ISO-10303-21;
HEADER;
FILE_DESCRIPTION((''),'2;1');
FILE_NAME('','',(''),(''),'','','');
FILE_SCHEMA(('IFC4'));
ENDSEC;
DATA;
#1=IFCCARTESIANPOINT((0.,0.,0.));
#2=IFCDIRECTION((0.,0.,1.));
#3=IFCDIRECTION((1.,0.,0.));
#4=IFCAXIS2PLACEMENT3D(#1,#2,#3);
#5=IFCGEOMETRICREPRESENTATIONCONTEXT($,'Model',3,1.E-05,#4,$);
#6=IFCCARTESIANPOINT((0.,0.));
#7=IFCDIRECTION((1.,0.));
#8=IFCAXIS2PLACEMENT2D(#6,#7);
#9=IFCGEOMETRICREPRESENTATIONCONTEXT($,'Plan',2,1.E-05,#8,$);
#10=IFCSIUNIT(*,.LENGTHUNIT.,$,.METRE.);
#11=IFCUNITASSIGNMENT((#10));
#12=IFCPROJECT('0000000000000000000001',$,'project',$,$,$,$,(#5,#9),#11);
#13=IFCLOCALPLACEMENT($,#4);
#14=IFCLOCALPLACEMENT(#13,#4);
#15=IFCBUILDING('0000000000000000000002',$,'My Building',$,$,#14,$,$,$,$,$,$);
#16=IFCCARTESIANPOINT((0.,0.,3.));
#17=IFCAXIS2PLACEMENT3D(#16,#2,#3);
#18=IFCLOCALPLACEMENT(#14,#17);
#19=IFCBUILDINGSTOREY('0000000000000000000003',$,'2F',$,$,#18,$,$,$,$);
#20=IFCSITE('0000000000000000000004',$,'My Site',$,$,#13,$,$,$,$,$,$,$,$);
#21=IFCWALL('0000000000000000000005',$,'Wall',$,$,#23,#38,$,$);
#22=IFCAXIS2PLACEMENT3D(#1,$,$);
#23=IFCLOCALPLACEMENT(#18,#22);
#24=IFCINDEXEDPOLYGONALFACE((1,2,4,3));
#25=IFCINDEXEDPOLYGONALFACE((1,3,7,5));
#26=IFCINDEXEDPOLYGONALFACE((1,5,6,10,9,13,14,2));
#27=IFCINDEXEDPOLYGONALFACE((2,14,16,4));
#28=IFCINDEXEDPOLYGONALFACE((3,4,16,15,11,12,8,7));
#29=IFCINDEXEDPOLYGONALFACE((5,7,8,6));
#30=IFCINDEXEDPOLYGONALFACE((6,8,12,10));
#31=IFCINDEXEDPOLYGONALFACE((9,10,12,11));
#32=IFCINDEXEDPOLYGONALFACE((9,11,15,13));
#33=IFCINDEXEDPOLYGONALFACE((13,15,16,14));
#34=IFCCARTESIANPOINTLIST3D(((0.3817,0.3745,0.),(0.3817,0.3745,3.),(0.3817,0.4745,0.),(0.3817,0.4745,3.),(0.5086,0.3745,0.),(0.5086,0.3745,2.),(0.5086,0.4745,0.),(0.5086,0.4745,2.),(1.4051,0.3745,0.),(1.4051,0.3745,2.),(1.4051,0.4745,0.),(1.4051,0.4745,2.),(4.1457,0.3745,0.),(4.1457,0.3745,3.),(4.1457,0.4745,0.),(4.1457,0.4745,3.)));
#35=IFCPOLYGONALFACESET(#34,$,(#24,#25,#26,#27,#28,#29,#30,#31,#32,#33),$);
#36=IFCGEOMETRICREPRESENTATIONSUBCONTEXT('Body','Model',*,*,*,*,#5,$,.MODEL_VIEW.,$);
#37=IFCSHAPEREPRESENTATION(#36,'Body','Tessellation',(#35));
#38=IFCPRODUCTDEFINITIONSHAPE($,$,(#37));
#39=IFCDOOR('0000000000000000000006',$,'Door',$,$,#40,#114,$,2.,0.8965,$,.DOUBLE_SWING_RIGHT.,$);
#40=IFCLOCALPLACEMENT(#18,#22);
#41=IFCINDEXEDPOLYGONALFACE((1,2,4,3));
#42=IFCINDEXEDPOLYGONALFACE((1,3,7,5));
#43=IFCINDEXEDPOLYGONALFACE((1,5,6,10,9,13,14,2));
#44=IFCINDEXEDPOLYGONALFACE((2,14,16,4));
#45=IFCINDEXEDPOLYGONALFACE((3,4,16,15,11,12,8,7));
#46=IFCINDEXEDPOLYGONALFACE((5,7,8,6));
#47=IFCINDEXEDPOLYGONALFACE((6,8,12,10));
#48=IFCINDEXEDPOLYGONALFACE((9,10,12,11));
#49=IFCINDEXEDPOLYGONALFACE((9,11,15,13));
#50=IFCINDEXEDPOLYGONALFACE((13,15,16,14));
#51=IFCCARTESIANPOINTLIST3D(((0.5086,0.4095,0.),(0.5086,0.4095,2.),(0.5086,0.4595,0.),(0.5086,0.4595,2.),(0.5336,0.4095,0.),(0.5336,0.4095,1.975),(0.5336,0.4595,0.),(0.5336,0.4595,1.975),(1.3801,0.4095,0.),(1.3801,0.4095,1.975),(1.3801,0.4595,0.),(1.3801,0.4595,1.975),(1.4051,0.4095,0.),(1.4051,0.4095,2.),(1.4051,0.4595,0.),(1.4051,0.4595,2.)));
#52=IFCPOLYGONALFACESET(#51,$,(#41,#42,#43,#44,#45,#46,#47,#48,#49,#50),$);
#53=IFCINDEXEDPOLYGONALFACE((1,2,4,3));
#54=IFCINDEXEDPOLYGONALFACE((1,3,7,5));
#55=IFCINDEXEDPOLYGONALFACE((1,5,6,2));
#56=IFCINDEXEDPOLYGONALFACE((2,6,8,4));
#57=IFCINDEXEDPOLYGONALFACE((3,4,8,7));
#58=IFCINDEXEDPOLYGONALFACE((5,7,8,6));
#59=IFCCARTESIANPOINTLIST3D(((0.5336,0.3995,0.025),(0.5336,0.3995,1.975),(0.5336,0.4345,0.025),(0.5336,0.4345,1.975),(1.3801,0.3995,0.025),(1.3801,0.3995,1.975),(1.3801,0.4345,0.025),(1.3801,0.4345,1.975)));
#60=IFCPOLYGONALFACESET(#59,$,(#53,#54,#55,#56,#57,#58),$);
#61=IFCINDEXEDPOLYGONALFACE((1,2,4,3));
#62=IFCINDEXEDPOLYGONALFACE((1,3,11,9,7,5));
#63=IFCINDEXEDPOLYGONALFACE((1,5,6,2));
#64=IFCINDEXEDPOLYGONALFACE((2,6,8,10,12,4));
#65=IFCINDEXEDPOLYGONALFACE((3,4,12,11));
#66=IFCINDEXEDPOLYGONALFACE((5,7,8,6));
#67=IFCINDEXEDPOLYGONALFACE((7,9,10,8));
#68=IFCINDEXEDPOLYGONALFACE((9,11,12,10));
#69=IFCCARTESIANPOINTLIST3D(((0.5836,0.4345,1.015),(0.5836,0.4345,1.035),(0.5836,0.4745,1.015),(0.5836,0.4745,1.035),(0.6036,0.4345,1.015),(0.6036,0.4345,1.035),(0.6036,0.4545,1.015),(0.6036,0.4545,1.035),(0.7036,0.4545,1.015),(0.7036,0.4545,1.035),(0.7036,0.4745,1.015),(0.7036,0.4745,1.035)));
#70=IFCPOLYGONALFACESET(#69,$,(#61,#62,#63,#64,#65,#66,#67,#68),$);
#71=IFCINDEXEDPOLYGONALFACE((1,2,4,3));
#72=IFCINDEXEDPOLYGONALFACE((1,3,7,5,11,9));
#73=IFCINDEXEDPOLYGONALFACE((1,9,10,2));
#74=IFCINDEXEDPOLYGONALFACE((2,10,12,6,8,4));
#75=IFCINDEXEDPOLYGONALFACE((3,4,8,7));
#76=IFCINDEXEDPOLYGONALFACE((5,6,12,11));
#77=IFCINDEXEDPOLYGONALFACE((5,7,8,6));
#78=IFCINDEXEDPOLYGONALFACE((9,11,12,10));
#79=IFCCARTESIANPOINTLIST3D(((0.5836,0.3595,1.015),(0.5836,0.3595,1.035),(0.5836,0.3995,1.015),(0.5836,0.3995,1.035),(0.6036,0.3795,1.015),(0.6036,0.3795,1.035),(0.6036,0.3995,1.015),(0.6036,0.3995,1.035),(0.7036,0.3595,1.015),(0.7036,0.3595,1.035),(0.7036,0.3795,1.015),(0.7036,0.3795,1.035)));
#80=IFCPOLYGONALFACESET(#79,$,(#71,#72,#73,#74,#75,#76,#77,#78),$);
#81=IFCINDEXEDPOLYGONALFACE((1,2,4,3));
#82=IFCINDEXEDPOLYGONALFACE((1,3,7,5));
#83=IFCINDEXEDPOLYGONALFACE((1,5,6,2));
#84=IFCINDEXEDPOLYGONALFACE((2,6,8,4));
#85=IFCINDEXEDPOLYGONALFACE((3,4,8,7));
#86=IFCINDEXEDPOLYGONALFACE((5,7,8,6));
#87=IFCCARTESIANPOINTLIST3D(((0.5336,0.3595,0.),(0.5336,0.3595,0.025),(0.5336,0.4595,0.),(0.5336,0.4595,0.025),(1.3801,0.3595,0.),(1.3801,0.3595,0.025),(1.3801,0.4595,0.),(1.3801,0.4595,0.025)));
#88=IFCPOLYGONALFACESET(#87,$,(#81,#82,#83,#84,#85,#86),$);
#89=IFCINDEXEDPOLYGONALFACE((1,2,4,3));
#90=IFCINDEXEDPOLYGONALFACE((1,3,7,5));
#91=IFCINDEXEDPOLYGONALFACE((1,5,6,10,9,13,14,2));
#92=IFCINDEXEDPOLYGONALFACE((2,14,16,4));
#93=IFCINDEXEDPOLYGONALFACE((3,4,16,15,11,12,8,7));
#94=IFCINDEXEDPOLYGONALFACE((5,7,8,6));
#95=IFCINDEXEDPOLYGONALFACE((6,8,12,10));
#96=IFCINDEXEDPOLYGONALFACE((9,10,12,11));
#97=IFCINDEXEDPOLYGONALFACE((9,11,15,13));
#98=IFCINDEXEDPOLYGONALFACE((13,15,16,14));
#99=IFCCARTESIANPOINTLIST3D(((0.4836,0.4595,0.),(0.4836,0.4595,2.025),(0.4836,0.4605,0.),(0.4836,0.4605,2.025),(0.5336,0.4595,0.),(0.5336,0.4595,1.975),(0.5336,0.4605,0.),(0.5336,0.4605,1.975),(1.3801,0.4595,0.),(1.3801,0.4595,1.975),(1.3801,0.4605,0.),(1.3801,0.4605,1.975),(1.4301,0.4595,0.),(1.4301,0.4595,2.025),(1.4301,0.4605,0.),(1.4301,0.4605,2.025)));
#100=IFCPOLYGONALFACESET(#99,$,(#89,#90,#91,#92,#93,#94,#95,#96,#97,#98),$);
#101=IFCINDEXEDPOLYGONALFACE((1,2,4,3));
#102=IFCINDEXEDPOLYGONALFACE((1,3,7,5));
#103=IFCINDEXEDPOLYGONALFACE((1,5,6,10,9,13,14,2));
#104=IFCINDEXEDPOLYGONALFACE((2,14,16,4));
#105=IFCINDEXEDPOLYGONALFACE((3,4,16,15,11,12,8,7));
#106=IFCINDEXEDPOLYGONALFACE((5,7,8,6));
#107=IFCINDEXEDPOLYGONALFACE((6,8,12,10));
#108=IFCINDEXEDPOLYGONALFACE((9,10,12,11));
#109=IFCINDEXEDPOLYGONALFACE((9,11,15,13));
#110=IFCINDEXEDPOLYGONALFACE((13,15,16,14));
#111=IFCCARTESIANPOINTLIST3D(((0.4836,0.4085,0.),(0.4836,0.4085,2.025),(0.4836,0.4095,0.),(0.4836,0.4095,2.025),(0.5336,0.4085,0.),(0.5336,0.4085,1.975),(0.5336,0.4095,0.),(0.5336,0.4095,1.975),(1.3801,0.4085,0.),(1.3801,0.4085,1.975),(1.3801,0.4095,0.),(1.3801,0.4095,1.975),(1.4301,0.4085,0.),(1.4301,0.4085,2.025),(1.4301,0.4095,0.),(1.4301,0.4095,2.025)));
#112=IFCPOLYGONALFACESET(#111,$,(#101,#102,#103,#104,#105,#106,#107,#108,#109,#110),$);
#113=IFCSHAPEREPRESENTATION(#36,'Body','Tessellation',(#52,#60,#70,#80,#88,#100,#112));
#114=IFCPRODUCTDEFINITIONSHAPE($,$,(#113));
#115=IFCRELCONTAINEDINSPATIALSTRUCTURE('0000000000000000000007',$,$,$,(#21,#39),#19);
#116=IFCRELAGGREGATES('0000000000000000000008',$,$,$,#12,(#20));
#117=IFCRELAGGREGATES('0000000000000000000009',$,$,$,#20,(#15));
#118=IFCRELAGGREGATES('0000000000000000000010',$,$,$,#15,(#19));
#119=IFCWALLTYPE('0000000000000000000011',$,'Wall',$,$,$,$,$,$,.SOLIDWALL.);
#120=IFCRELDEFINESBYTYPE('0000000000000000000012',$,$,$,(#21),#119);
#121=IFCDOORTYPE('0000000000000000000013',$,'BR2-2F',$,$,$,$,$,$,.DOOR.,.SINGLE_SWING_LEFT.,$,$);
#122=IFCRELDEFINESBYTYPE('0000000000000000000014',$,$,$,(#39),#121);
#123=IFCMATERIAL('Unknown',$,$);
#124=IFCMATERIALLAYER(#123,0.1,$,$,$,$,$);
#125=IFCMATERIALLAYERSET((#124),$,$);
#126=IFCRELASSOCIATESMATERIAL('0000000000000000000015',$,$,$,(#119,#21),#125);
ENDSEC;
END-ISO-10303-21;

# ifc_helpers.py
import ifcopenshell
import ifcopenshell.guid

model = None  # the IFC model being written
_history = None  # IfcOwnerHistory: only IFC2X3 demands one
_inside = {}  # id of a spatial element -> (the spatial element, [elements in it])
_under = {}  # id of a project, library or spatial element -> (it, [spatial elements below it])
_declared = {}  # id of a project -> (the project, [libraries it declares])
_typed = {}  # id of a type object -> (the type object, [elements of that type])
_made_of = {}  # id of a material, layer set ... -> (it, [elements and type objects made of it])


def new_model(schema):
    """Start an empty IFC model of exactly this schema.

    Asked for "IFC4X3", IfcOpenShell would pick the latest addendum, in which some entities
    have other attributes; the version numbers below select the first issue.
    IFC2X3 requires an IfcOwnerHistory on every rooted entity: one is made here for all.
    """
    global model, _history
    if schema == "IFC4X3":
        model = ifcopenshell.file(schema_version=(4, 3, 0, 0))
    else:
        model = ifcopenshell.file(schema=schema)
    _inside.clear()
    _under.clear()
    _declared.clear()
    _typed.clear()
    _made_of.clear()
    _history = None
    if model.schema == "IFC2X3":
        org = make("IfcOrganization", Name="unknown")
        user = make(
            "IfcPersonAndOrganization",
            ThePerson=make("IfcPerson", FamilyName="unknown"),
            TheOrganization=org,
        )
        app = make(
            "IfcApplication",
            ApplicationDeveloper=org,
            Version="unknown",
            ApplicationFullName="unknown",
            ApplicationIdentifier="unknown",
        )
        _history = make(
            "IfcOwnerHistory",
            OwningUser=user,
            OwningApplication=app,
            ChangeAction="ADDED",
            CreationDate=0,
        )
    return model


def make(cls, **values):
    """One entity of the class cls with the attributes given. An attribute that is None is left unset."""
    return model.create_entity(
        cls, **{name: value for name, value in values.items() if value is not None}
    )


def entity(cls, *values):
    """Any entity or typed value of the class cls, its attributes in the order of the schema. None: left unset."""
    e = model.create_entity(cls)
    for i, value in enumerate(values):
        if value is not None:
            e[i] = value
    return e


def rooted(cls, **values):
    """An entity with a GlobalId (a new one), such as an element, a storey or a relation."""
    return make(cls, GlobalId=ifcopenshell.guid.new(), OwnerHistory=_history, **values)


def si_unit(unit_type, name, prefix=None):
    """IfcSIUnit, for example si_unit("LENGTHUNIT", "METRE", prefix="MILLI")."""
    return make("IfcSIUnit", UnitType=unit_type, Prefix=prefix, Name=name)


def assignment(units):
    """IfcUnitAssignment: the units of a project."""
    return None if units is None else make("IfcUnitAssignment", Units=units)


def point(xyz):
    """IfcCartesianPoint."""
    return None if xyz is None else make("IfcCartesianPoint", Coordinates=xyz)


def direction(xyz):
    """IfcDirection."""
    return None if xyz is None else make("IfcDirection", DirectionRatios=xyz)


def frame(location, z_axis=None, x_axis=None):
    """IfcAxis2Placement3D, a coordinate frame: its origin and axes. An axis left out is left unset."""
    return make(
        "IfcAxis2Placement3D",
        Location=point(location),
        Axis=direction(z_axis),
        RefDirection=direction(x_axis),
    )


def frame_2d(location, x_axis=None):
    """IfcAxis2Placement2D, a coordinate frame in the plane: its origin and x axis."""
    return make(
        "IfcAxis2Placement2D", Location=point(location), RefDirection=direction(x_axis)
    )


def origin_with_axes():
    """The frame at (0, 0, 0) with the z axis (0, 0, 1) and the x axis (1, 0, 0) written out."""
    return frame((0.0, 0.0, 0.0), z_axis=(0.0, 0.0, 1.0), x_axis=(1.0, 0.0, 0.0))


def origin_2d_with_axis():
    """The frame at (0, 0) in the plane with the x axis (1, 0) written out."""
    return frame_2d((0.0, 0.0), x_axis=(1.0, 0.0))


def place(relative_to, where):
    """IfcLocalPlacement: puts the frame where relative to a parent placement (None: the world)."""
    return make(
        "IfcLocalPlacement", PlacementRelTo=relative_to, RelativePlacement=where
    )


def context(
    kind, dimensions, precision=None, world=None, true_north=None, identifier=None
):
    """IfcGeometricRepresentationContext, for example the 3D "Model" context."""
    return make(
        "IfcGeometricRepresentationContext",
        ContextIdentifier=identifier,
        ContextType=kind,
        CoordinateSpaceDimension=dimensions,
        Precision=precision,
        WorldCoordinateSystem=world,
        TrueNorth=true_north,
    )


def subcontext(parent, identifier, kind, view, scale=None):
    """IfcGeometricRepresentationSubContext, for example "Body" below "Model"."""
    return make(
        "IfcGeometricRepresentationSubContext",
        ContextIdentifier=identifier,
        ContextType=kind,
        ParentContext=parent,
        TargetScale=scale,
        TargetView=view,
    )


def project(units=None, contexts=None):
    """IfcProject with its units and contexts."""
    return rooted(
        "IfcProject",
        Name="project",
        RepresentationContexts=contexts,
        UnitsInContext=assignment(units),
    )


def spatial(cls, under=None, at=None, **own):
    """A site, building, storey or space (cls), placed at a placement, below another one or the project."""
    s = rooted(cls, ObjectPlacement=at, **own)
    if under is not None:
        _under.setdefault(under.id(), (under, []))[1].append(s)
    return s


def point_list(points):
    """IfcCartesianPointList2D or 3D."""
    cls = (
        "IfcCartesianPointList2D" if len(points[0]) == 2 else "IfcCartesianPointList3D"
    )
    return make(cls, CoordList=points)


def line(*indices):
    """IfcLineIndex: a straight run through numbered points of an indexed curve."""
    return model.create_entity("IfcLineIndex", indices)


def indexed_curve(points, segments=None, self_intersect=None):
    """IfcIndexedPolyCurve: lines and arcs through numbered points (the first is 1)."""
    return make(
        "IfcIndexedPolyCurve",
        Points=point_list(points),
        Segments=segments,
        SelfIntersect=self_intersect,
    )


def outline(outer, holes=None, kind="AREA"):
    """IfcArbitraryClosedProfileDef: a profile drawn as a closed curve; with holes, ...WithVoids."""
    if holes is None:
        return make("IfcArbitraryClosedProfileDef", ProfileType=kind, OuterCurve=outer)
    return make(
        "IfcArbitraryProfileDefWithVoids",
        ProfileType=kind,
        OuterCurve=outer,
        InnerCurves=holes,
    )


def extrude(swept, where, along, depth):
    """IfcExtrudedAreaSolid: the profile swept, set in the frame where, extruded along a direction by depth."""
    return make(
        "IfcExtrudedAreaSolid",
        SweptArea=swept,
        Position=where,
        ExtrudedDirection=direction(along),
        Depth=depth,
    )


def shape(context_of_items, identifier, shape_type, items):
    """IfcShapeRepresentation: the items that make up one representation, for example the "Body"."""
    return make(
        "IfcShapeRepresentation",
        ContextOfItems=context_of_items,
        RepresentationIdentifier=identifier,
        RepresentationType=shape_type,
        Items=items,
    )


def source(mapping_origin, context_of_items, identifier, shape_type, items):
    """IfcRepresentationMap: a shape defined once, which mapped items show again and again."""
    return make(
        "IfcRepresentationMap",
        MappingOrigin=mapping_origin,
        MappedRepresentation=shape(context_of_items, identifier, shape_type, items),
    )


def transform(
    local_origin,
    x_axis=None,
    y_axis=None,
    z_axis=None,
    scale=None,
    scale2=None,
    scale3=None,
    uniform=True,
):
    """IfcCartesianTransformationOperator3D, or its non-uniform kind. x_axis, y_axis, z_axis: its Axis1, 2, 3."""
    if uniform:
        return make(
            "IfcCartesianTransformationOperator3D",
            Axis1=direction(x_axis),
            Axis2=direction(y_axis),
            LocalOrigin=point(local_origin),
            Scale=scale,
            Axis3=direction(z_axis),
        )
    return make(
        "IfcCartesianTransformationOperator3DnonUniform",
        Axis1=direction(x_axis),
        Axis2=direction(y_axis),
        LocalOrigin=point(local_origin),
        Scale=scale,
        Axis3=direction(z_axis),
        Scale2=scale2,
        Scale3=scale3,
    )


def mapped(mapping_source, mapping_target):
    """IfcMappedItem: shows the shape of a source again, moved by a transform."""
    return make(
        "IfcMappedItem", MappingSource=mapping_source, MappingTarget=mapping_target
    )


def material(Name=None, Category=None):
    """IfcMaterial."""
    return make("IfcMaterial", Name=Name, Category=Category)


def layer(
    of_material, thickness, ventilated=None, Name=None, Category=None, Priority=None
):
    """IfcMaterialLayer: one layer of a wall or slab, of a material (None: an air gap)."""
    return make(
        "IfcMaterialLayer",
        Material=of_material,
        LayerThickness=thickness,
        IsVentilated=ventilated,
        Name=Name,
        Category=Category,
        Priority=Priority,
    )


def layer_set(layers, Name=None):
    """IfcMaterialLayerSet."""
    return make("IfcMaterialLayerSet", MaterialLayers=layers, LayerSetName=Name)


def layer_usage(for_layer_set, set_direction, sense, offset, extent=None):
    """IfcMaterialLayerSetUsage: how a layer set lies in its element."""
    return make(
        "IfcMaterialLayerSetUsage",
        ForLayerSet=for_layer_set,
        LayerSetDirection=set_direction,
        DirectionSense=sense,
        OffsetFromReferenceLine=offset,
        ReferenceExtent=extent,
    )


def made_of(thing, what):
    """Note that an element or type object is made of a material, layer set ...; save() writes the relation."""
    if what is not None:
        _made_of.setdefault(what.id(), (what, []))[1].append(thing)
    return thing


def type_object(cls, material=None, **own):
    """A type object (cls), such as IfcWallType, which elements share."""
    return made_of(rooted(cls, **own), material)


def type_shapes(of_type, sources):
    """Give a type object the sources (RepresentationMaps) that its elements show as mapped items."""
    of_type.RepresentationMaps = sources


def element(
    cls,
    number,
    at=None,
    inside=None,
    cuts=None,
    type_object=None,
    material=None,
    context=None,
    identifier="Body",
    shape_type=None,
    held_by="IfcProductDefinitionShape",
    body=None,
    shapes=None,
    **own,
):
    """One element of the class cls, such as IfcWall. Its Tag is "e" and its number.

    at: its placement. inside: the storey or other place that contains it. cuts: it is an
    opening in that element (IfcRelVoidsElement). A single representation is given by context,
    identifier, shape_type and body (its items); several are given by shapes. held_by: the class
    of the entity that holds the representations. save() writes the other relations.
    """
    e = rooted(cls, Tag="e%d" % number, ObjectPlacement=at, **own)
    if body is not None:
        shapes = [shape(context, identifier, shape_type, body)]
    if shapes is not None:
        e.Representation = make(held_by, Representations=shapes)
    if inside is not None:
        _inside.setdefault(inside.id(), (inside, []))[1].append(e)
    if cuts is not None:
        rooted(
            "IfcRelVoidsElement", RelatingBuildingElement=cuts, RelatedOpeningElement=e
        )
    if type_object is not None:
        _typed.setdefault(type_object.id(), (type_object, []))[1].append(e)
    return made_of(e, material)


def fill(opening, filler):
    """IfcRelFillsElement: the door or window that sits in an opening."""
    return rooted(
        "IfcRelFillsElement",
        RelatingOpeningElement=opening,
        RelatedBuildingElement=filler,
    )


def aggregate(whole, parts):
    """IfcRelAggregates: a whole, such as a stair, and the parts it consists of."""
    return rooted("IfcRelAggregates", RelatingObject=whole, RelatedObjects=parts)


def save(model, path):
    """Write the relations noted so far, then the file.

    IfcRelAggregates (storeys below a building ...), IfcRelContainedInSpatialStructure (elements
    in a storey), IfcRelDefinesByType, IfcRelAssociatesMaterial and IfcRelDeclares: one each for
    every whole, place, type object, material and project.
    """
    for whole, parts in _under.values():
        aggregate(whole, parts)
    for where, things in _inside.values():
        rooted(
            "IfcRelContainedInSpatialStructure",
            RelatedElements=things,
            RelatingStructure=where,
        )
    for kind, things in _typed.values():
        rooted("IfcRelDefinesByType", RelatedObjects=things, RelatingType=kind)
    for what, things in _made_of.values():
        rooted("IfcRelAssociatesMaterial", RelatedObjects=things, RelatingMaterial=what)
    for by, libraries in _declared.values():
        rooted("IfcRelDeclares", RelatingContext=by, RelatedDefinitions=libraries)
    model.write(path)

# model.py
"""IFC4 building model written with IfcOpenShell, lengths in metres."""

from ifc_helpers import new_model, entity, si_unit, frame, origin_with_axes, origin_2d_with_axis, place, context, subcontext, project, spatial, line, indexed_curve, outline, extrude, shape, source, transform, mapped, material, layer, layer_set, layer_usage, type_object, type_shapes, element, fill, save


model = new_model("IFC4")

# Units and contexts
model_context = context("Model", 3, precision=1e-05, world=origin_with_axes())
plan_context = context("Plan", 2, precision=1e-05, world=origin_2d_with_axis())
body_context_1 = subcontext(model_context, "Body", "Model", "MODEL_VIEW")
body_context_2 = subcontext(plan_context, "Body", "Plan", "PLAN_VIEW")
ifc_project = project(units=[si_unit("LENGTHUNIT", "METRE")], contexts=[model_context, plan_context])

# Site, building, storey
site_placement = place(None, origin_with_axes())
site = spatial("IfcSite", under=ifc_project, at=site_placement, Name="My Site")
building_placement = place(site_placement, origin_with_axes())
building = spatial("IfcBuilding", under=site, at=building_placement, Name="My Building")
storey_placement = place(building_placement, frame((0.0, 0.0, 3.0), z_axis=(0.0, 0.0, 1.0), x_axis=(1.0, 0.0, 0.0)))
storey = spatial("IfcBuildingStorey", under=building, at=storey_placement, Name="2F")

# Shared definitions
ifc_material = material(Name="Unknown")

# Shared definitions
ifc_layer_1 = layer(ifc_material, 0.1)
ifc_layer_set_1 = layer_set([ifc_layer_1])
wall_type_1 = type_object("IfcWallType", Name="Wall", PredefinedType="SOLIDWALL", material=ifc_layer_set_1)

# Wall, opening, door
ifc_layer_usage_1 = layer_usage(ifc_layer_set_1, "AXIS2", "POSITIVE", 0.0)
wall_1_placement = place(storey_placement, frame((4.1457, 0.4745, 0.0), z_axis=(0.0, 0.0, 1.0), x_axis=(-1.0, 0.0, 0.0)))
wall_1 = element("IfcWall", 1, at=wall_1_placement, inside=storey, type_object=wall_type_1, material=ifc_layer_usage_1, Name="Wall", context=body_context_1, shape_type="SweptSolid", body=[
    extrude(outline(indexed_curve([(0.0, 0.0), (0.0, 0.1), (3.764, 0.1), (3.764, 0.0)], segments=[line(1, 2, 3, 4, 1)])), origin_with_axes(), (0.0, 0.0, 1.0), 3.0),
])
shared_shape_1 = source(origin_with_axes(), body_context_1, "Body", "SweptSolid", [
    extrude(outline(indexed_curve([(0.0, 0.0), (0.8965, 0.0), (0.8965, 2.0), (0.0, 2.0)], segments=[line(1, 2, 3, 4, 1)])), frame((0.0, -0.6, 0.0), z_axis=(0.0, -1.0, 0.0), x_axis=(1.0, 0.0, 0.0)), (0.0, 0.0, -1.0), 1.2),
])
opening_1_placement = place(wall_1_placement, frame((2.7406, 0.015, 0.0), z_axis=(0.0, 0.0, 1.0), x_axis=(1.0, 0.0, 0.0)))
opening_1 = element("IfcOpeningElement", 2, at=opening_1_placement, cuts=wall_1, PredefinedType="OPENING", context=body_context_1, shape_type="MappedRepresentation", body=[
    mapped(shared_shape_1, transform((0.0, 0.0, 0.0), x_axis=(1.0, 0.0, 0.0), y_axis=(0.0, 1.0, 0.0), z_axis=(0.0, 0.0, 1.0), scale=1.0)),
])
door_type_1 = type_object("IfcDoorType", Name="BR2-2F", OperationType="SINGLE_SWING_LEFT", PredefinedType="DOOR")
shared_shape_2 = source(origin_with_axes(), body_context_1, "Body", "SweptSolid", [
    extrude(outline(indexed_curve([(0.0, 0.0), (0.0, 2.0), (0.8965, 2.0), (0.8965, 0.0), (0.8715, 0.0), (0.8715, 1.975), (0.025, 1.975), (0.025, 0.0)], segments=[line(1, 2, 3, 4, 5, 6, 7, 8, 1)])), frame((0.0, 0.0, 0.0), z_axis=(0.0, -1.0, 0.0), x_axis=(1.0, 0.0, 0.0)), (0.0, 0.0, -1.0), 0.05),
    extrude(outline(indexed_curve([(0.0, 0.0), (0.8465, 0.0), (0.8465, 0.035), (0.0, 0.035)], segments=[line(1, 2, 3, 4, 1)])), frame((0.025, 0.025, 0.025), z_axis=(0.0, 0.0, 1.0), x_axis=(1.0, 0.0, 0.0)), (0.0, 0.0, 1.0), 1.95),
    extrude(outline(indexed_curve([(0.0, 0.0), (0.0, -0.04), (-0.12, -0.04), (-0.12, -0.02), (-0.02, -0.02), (-0.02, 0.0)], segments=[line(1, 2, 3, 4, 5, 6, 1)])), frame((0.8215, 0.025, 1.015), z_axis=(0.0, 0.0, 1.0), x_axis=(1.0, 0.0, 0.0)), (0.0, 0.0, 1.0), 0.02),
    extrude(outline(indexed_curve([(0.0, 0.0), (0.0, 0.04), (-0.12, 0.04), (-0.12, 0.02), (-0.02, 0.02), (-0.02, 0.0)], segments=[line(1, 2, 3, 4, 5, 6, 1)])), frame((0.8215, 0.06, 1.015), z_axis=(0.0, 0.0, 1.0), x_axis=(1.0, 0.0, 0.0)), (0.0, 0.0, 1.0), 0.02),
    extrude(outline(indexed_curve([(0.0, 0.0), (0.8465, 0.0), (0.8465, 0.1), (0.0, 0.1)], segments=[line(1, 2, 3, 4, 1)])), frame((0.025, 0.0, 0.0), z_axis=(0.0, 0.0, 1.0), x_axis=(1.0, 0.0, 0.0)), (0.0, 0.0, 1.0), 0.025),
    extrude(outline(indexed_curve([(0.0, 0.0), (0.0, 2.025), (0.9465, 2.025), (0.9465, 0.0), (0.8965, 0.0), (0.8965, 1.975), (0.05, 1.975), (0.05, 0.0)], segments=[line(1, 2, 3, 4, 5, 6, 7, 8, 1)])), frame((-0.025, -0.001, 0.0), z_axis=(0.0, -1.0, 0.0), x_axis=(1.0, 0.0, 0.0)), (0.0, 0.0, -1.0), 0.001),
    extrude(outline(indexed_curve([(0.0, 0.0), (0.0, 2.025), (0.9465, 2.025), (0.9465, 0.0), (0.8965, 0.0), (0.8965, 1.975), (0.05, 1.975), (0.05, 0.0)], segments=[line(1, 2, 3, 4, 5, 6, 7, 8, 1)])), frame((-0.025, 0.05, 0.0), z_axis=(0.0, -1.0, 0.0), x_axis=(1.0, 0.0, 0.0)), (0.0, 0.0, -1.0), 0.001),
])
shared_shape_3 = source(origin_with_axes(), body_context_2, "Body", "Curve2D", [
    entity("IfcIndexedPolyCurve", entity("IfcCartesianPointList2D", [[0.0, 0.0], [0.025, 0.0], [0.025, 0.05], [0.0, 0.05]]), [entity("IfcLineIndex", [1, 2, 3, 4, 1])]),
    entity("IfcIndexedPolyCurve", entity("IfcCartesianPointList2D", [[0.8965, 0.0], [0.8715, 0.0], [0.8715, 0.05], [0.8965, 0.05]]), [entity("IfcLineIndex", [1, 2, 3, 4, 1])]),
    entity("IfcIndexedPolyCurve", entity("IfcCartesianPointList2D", [[0.025, 0.05], [0.025, -0.7965], [0.06, -0.7965]])),
    entity("IfcTrimmedCurve", entity("IfcEllipse", entity("IfcAxis2Placement2D", entity("IfcCartesianPoint", [0.06, 0.05]), entity("IfcDirection", [1.0, 0.0])), 0.8115, 0.8465), [entity("IfcCartesianPoint", [0.06, -0.7965])], [entity("IfcCartesianPoint", [0.06, 0.8965])], True, "CARTESIAN"),
    entity("IfcIndexedPolyCurve", entity("IfcCartesianPointList2D", [[0.025, 0.05], [0.06, 0.05], [0.06, 0.8965], [0.025, 0.8965]]), [entity("IfcLineIndex", [1, 2, 3, 4, 1])]),
])
type_shapes(door_type_1, [shared_shape_2, shared_shape_3])
door_1_placement = place(opening_1_placement, frame((0.0, 0.0, 0.0), z_axis=(0.0, 0.0, 1.0), x_axis=(1.0, 0.0, 0.0)))
door_1 = element("IfcDoor", 3, at=door_1_placement, inside=storey, type_object=door_type_1, Name="Door", OperationType="DOUBLE_SWING_RIGHT", OverallHeight=2.0, OverallWidth=0.8965, shapes=[
    shape(body_context_1, "Body", "MappedRepresentation", [mapped(shared_shape_2, transform((0.0, 0.0, 0.0), x_axis=(1.0, 0.0, 0.0), y_axis=(0.0, 1.0, 0.0), z_axis=(0.0, 0.0, 1.0), scale=1.0))]),
    shape(body_context_2, "Body", "MappedRepresentation", [mapped(shared_shape_3, transform((0.0, 0.0, 0.0), x_axis=(1.0, 0.0, 0.0), y_axis=(0.0, 1.0, 0.0), z_axis=(0.0, 0.0, 1.0), scale=1.0))]),
])
fill(opening_1, door_1)

save(model, "model.ifc")
